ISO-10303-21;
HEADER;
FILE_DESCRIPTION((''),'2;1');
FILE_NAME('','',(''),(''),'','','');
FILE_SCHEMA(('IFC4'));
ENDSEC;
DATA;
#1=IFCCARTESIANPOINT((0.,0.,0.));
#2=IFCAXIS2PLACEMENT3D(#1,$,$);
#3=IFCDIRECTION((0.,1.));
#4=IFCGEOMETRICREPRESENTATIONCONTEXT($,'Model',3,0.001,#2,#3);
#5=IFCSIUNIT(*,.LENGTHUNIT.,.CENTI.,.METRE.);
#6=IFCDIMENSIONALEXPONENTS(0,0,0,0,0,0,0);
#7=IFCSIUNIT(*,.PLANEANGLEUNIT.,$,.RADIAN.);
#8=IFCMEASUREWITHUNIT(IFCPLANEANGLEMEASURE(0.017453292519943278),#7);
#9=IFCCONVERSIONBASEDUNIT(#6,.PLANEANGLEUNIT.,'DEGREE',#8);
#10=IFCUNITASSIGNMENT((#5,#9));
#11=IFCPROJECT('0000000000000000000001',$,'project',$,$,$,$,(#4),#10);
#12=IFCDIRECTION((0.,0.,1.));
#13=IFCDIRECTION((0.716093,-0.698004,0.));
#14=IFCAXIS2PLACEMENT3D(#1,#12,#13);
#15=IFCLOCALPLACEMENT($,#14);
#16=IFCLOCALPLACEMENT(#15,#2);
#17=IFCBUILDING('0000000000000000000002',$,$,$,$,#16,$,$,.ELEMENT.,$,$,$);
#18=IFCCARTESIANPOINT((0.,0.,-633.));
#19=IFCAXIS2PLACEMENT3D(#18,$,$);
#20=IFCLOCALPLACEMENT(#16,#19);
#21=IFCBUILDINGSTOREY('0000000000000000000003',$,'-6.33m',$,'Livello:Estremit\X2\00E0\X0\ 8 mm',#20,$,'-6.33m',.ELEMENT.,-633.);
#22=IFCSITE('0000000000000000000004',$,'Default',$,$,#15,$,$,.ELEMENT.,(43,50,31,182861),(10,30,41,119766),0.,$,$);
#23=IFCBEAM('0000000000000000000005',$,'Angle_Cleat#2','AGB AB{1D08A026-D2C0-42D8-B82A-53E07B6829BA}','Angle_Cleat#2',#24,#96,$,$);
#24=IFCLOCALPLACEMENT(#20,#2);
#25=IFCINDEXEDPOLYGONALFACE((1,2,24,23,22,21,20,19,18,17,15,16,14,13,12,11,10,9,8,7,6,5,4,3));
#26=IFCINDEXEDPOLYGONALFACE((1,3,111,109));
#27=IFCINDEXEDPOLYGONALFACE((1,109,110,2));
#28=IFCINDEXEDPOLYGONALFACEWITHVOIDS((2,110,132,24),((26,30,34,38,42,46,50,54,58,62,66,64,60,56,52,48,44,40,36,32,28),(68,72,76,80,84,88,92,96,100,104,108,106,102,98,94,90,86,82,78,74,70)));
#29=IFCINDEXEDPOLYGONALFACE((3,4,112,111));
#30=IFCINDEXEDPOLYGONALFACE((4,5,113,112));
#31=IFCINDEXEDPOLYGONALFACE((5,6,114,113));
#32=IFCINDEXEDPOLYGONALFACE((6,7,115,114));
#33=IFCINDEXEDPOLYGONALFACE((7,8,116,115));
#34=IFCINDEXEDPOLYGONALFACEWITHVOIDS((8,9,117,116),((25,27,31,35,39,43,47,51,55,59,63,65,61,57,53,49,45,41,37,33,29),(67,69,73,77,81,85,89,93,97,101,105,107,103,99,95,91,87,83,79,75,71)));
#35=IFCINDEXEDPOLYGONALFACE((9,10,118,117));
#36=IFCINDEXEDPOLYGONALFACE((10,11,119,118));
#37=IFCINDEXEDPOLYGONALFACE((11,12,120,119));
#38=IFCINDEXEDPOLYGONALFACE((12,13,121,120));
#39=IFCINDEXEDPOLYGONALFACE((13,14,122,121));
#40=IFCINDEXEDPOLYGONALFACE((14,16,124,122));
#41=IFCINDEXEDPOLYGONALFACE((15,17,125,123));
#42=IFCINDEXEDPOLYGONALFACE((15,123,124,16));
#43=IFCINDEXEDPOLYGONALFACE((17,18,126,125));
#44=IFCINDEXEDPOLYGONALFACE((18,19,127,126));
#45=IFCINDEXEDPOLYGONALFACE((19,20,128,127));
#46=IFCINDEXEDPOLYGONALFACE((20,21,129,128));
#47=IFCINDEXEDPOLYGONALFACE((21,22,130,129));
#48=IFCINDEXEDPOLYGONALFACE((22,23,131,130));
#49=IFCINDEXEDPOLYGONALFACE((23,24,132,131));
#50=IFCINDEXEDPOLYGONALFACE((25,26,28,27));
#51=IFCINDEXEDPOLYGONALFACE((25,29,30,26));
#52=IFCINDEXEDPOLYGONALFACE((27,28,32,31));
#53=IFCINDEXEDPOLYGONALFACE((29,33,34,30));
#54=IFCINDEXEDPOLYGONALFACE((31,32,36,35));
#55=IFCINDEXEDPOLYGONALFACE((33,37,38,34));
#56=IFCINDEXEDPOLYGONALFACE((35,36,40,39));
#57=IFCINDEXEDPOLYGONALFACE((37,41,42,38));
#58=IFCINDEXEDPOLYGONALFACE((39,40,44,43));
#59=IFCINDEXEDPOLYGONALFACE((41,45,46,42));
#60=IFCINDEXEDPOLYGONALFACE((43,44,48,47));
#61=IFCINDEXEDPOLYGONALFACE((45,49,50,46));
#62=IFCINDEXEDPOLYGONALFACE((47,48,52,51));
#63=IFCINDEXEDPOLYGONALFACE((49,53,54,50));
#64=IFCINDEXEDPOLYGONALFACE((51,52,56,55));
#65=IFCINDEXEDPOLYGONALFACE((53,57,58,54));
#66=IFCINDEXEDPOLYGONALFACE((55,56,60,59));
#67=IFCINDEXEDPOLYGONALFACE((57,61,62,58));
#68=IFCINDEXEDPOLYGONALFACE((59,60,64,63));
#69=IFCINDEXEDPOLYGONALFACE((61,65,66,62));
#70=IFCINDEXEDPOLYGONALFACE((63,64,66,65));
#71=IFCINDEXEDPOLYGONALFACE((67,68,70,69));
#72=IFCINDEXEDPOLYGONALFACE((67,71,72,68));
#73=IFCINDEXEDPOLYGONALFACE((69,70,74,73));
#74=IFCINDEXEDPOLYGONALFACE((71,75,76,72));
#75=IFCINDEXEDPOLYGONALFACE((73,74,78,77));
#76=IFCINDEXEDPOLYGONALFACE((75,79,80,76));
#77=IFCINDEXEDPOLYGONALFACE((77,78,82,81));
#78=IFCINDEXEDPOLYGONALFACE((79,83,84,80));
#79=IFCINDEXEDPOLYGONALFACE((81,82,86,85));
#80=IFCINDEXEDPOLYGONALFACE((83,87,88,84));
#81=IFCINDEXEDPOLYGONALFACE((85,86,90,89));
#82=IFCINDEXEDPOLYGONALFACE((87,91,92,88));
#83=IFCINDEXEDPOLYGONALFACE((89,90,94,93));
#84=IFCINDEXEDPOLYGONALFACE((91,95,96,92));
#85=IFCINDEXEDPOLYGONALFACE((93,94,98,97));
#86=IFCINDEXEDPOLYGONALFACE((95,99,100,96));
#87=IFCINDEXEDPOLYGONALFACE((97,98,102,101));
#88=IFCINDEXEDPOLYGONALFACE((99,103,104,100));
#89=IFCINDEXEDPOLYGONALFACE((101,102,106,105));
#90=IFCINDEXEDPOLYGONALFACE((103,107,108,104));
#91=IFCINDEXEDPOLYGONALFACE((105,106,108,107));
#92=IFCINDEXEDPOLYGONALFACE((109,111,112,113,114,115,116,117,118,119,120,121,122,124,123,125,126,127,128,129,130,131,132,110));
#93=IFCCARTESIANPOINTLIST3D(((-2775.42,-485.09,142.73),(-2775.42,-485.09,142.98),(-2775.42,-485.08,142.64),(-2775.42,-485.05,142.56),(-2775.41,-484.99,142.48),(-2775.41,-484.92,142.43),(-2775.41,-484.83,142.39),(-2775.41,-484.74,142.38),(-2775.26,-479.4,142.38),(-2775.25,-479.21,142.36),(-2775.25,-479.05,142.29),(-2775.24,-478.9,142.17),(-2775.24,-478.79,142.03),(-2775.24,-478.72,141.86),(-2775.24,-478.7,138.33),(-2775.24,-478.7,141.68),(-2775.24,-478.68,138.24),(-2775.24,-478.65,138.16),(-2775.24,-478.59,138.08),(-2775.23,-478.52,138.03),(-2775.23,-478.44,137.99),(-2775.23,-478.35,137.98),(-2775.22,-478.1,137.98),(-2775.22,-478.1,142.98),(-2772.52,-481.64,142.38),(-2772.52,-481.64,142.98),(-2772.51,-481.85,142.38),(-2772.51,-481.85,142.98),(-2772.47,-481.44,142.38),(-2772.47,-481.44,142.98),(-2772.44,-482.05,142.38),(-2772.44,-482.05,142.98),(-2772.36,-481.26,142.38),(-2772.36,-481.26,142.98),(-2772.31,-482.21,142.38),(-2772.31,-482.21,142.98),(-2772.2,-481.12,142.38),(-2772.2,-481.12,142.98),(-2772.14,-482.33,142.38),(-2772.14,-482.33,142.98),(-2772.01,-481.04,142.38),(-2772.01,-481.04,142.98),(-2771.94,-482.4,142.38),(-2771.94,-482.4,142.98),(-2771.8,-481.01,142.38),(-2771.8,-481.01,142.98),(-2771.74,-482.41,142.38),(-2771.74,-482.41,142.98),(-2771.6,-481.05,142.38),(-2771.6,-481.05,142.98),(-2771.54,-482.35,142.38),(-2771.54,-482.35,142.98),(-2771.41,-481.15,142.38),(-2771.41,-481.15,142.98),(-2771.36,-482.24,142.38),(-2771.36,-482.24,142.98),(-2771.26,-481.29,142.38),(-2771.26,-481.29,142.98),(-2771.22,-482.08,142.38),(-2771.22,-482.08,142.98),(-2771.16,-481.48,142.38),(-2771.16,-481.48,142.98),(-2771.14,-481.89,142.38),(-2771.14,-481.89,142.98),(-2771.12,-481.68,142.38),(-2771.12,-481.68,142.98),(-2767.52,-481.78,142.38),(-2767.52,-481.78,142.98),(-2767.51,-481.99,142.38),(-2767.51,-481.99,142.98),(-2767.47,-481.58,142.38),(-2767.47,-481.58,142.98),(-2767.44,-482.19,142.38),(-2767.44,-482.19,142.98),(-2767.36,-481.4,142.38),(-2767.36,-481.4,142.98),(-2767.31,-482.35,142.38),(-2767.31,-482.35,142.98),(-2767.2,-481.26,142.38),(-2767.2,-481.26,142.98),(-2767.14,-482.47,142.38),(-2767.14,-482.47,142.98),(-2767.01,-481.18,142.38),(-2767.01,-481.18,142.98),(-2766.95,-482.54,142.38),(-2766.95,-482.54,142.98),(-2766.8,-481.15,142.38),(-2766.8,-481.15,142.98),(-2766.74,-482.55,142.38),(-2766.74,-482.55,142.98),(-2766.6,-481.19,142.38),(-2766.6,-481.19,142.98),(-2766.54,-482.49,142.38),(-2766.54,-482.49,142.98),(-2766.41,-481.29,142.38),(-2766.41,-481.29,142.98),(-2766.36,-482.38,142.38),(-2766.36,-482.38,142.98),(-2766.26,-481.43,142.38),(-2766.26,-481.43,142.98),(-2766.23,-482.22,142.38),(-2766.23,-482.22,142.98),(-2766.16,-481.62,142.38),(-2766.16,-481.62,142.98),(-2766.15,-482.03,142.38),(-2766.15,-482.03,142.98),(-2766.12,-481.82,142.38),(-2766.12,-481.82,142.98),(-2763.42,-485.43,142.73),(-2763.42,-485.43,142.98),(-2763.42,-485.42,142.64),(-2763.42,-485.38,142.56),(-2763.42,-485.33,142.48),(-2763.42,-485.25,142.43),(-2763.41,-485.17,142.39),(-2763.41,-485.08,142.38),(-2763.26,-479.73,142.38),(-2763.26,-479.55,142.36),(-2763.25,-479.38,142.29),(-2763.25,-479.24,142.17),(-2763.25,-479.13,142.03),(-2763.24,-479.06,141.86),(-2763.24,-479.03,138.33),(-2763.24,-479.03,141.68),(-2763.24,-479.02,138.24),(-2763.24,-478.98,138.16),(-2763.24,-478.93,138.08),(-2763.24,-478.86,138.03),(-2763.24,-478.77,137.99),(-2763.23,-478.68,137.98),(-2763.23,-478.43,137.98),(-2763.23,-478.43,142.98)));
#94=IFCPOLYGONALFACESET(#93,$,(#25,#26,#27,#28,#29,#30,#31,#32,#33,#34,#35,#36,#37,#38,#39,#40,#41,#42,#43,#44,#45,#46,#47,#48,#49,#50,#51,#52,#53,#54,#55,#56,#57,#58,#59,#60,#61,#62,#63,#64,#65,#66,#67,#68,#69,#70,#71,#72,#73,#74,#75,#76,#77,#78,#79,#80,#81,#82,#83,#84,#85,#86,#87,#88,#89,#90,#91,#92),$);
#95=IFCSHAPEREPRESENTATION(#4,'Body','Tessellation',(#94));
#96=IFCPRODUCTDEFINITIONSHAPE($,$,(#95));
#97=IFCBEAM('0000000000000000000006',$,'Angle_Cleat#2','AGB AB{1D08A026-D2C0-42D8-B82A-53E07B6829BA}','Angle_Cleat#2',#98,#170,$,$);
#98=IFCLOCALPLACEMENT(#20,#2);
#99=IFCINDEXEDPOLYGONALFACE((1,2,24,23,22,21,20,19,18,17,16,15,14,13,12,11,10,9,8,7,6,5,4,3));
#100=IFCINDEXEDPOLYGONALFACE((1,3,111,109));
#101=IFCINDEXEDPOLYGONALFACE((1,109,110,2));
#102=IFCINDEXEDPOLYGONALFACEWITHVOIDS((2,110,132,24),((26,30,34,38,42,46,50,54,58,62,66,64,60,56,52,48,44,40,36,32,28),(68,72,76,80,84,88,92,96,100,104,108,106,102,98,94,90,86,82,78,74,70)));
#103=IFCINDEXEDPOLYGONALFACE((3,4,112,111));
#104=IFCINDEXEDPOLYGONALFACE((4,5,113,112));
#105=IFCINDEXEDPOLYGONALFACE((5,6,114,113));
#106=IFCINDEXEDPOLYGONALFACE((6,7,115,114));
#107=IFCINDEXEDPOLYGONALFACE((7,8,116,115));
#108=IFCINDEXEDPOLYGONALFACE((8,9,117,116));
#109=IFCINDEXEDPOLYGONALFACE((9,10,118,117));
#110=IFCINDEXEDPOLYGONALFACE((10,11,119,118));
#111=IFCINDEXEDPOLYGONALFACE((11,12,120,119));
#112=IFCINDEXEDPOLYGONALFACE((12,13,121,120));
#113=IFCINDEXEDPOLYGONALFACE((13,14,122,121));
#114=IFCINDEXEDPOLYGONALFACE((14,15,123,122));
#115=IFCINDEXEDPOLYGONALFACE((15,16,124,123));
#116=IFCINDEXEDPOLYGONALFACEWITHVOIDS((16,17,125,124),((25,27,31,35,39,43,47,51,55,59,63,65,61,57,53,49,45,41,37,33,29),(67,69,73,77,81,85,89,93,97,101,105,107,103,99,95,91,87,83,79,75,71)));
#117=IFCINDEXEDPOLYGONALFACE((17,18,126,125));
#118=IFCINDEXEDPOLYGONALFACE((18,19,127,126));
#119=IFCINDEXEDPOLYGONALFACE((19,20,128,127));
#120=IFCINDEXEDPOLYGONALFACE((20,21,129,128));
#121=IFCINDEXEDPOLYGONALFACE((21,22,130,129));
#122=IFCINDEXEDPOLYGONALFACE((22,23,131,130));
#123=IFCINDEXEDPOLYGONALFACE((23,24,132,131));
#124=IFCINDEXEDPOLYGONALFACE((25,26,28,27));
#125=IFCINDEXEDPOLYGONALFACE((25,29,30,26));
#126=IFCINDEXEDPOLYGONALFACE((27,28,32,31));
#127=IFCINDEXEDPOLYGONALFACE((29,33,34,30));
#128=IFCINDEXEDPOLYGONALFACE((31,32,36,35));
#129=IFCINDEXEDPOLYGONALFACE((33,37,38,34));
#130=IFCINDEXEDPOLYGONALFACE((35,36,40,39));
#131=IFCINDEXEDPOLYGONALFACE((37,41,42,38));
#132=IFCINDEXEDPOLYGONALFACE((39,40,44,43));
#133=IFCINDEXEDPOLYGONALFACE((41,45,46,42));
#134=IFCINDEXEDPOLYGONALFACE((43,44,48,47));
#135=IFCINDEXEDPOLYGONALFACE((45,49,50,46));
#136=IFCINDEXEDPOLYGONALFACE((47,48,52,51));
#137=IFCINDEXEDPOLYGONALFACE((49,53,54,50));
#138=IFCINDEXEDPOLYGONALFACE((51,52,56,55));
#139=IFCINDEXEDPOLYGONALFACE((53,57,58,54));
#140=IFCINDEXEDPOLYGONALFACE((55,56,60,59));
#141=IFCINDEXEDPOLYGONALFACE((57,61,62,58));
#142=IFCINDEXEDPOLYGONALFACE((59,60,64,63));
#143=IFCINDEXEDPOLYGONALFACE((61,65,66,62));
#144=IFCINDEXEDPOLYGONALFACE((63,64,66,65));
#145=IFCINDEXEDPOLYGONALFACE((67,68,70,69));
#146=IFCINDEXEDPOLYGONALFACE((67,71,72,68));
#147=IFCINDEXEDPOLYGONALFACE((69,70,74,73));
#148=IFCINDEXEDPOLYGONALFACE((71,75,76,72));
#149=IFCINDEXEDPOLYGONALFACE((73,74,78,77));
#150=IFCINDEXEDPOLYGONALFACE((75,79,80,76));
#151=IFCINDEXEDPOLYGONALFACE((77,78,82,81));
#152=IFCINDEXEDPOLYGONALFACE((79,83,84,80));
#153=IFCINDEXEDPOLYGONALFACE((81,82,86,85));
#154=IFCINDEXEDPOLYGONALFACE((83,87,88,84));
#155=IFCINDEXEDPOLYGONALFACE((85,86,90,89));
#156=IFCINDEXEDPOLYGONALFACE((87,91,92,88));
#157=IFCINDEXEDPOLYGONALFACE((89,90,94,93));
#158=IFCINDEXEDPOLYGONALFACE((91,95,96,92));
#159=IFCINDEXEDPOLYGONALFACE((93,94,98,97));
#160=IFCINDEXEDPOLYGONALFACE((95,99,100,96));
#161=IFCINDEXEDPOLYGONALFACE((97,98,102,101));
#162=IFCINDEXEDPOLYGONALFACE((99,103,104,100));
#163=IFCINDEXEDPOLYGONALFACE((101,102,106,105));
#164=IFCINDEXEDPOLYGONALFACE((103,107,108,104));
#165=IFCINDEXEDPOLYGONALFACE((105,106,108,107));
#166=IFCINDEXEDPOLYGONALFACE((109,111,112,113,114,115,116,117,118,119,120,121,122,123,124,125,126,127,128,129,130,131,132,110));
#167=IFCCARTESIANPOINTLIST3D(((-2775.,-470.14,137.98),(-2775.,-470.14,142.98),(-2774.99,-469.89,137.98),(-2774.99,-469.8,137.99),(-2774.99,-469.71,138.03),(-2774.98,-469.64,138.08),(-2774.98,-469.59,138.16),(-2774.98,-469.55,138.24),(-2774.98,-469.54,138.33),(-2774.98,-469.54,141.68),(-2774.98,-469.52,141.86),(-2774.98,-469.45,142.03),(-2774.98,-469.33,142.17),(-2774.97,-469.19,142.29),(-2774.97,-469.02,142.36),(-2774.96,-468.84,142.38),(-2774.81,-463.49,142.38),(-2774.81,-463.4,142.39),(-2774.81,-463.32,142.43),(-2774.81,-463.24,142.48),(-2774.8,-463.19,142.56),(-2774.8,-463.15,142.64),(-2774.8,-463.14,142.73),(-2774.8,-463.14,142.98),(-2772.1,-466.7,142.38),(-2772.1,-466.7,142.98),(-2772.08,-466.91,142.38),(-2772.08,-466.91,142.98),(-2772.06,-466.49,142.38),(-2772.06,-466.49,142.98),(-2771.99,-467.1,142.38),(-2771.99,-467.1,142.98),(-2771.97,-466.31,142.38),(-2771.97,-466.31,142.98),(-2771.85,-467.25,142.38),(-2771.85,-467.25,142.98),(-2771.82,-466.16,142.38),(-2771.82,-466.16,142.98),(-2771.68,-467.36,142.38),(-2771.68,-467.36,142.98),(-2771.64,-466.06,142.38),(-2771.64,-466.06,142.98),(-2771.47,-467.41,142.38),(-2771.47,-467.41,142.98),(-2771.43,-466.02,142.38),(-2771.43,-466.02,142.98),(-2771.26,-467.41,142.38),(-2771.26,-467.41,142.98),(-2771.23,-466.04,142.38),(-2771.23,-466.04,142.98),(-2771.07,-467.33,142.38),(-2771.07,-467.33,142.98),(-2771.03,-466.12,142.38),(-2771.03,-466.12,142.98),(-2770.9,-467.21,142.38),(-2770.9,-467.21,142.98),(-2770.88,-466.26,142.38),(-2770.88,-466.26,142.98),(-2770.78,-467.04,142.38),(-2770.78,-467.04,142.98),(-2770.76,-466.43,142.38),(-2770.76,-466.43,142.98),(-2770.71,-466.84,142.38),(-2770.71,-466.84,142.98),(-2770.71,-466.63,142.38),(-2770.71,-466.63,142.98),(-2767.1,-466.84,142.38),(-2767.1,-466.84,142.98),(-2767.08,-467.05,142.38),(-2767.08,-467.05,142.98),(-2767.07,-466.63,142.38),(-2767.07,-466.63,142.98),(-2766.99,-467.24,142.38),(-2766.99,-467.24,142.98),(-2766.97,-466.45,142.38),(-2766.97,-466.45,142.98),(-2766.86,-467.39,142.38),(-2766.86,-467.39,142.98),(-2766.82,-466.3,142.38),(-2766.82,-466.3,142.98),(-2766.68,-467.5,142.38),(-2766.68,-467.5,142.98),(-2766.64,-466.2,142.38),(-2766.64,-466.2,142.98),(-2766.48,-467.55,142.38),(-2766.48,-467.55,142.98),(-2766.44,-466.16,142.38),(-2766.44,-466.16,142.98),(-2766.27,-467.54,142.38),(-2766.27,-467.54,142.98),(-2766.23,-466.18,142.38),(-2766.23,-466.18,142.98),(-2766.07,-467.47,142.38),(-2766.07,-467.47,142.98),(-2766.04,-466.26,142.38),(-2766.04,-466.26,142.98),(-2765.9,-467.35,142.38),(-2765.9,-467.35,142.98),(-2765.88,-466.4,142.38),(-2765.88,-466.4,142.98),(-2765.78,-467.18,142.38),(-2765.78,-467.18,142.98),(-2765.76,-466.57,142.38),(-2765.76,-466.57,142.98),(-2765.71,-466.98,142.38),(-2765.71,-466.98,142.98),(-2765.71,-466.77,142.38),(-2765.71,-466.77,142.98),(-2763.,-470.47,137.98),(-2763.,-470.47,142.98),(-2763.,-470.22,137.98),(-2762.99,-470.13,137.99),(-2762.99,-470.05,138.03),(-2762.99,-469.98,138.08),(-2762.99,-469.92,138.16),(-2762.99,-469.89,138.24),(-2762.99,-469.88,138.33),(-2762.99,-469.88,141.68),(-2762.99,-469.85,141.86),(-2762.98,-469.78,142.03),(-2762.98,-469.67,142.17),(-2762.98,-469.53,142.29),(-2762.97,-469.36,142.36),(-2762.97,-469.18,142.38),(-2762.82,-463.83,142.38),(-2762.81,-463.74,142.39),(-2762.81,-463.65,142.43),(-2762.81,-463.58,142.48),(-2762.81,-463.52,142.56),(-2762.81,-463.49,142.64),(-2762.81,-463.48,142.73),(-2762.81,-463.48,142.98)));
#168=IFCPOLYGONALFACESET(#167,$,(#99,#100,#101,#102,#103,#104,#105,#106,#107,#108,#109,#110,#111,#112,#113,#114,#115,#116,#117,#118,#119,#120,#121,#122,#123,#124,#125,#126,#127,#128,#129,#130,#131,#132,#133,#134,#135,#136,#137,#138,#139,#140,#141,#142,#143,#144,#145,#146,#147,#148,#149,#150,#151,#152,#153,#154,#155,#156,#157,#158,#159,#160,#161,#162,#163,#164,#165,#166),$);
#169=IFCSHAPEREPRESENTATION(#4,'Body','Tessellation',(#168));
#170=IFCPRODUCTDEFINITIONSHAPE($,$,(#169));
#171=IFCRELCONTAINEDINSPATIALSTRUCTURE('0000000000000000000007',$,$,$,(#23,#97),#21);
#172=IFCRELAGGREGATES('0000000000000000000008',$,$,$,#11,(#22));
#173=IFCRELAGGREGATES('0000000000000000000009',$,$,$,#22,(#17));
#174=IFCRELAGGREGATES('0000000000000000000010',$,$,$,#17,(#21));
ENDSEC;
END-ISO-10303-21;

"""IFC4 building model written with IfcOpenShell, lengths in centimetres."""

from ifc_helpers import new_model, entity, si_unit, converted_unit, direction, frame, frame_2d, origin, place, context, project, spatial, circle, l_section, extrude, element, save


model = new_model("IFC4")

# Units and contexts
model_context = context("Model", 3, precision=0.001, world=origin(), true_north=direction((0.0, 1.0)))
ifc_project = project(units=[si_unit("LENGTHUNIT", "METRE", prefix="CENTI"), converted_unit("PLANEANGLEUNIT", "DEGREE", entity("IfcPlaneAngleMeasure", 0.017453292519943278), si_unit("PLANEANGLEUNIT", "RADIAN"), dimensions=[0, 0, 0, 0, 0, 0, 0])], contexts=[model_context])

# Site, building, storey
site_placement = place(None, frame((0.0, 0.0, 0.0), z_axis=(0.0, 0.0, 1.0), x_axis=(0.716093, -0.698004, 0.0)))
site = spatial("IfcSite", under=ifc_project, at=site_placement, Name="Default", CompositionType="ELEMENT", RefLatitude=(43, 50, 31, 182861), RefLongitude=(10, 30, 41, 119766), RefElevation=0.0)
building_placement = place(site_placement, origin())
building = spatial("IfcBuilding", under=site, at=building_placement, CompositionType="ELEMENT")
storey_placement = place(building_placement, frame((0.0, 0.0, -633.0)))
storey = spatial("IfcBuildingStorey", under=building, at=storey_placement, Name="-6.33m", ObjectType="Livello:Estremità 8 mm", LongName="-6.33m", CompositionType="ELEMENT", Elevation=-633.0)

# Beams, openings
beam_1_placement = place(storey_placement, frame((-2775.28, -480.35, 141.75), z_axis=(0.999608, -0.02798, 0.0), x_axis=(-0.02798, -0.999608, 0.0)))
beam_1 = element("IfcBeam", 1, at=beam_1_placement, inside=storey, Name="Angle_Cleat#2", Description="AGB AB{1D08A026-D2C0-42D8-B82A-53E07B6829BA}", ObjectType="Angle_Cleat#2", context=model_context, shape_type="SweptSolid", body=[
    extrude(l_section(Depth=5.0, Width=7.0, Thickness=0.6, FilletRadius=0.7, EdgeRadius=0.35, at=frame_2d((1.25, 1.27))), origin(), (0.0, 0.0, 1.0), 12.0),
])
opening_1_placement = place(beam_1_placement, frame((1.27, -0.6, 4.2), z_axis=(0.0, 1.0, 0.0), x_axis=(-1.0, 0.0, 0.0)))
element("IfcOpeningElement", 2, at=opening_1_placement, cuts=beam_1, ObjectType="Opening", context=model_context, shape_type="SweptSolid", body=[
    extrude(circle(Radius=0.7, at=frame_2d((0.0, -0.7), x_axis=(1.0, 0.0))), origin(), (0.0, 0.0, -1.0), 0.7),
])
opening_2_placement = place(beam_1_placement, frame((1.27, -0.6, 9.2), z_axis=(0.0, 1.0, 0.0), x_axis=(-1.0, 0.0, 0.0)))
element("IfcOpeningElement", 3, at=opening_2_placement, cuts=beam_1, ObjectType="Opening", context=model_context, shape_type="SweptSolid", body=[
    extrude(circle(Radius=0.7, at=frame_2d((0.0, -0.7), x_axis=(1.0, 0.0))), origin(), (0.0, 0.0, -1.0), 0.7),
])
beam_2_placement = place(storey_placement, frame((-2774.94, -467.89, 141.75), z_axis=(-0.999608, 0.02798, 0.0), x_axis=(0.02798, 0.999608, 0.0)))
beam_2 = element("IfcBeam", 4, at=beam_2_placement, inside=storey, Name="Angle_Cleat#2", Description="AGB AB{1D08A026-D2C0-42D8-B82A-53E07B6829BA}", ObjectType="Angle_Cleat#2", context=model_context, shape_type="SweptSolid", body=[
    extrude(l_section(Depth=5.0, Width=7.0, Thickness=0.6, FilletRadius=0.7, EdgeRadius=0.35, at=frame_2d((1.25, 1.27))), origin(), (0.0, 0.0, -1.0), 12.0),
])
opening_3_placement = place(beam_2_placement, frame((1.27, -0.6, -6.0), z_axis=(0.0, -1.0, 0.0), x_axis=(0.0, 0.0, 1.0)))
element("IfcOpeningElement", 5, at=opening_3_placement, cuts=beam_2, ObjectType="Opening", context=model_context, shape_type="SweptSolid", body=[
    extrude(circle(Radius=0.7, at=frame_2d((2.5, 0.0), x_axis=(1.0, 0.0))), origin(), (0.0, 0.0, 1.0), 0.7),
])
opening_4_placement = place(beam_2_placement, frame((1.27, -0.6, -6.0), z_axis=(0.0, -1.0, 0.0), x_axis=(0.0, 0.0, 1.0)))
element("IfcOpeningElement", 6, at=opening_4_placement, cuts=beam_2, ObjectType="Opening", context=model_context, shape_type="SweptSolid", body=[
    extrude(circle(Radius=0.7, at=frame_2d((-2.5, 0.0), x_axis=(1.0, 0.0))), origin(), (0.0, 0.0, 1.0), 0.7),
])

save(model, "model.ifc")
